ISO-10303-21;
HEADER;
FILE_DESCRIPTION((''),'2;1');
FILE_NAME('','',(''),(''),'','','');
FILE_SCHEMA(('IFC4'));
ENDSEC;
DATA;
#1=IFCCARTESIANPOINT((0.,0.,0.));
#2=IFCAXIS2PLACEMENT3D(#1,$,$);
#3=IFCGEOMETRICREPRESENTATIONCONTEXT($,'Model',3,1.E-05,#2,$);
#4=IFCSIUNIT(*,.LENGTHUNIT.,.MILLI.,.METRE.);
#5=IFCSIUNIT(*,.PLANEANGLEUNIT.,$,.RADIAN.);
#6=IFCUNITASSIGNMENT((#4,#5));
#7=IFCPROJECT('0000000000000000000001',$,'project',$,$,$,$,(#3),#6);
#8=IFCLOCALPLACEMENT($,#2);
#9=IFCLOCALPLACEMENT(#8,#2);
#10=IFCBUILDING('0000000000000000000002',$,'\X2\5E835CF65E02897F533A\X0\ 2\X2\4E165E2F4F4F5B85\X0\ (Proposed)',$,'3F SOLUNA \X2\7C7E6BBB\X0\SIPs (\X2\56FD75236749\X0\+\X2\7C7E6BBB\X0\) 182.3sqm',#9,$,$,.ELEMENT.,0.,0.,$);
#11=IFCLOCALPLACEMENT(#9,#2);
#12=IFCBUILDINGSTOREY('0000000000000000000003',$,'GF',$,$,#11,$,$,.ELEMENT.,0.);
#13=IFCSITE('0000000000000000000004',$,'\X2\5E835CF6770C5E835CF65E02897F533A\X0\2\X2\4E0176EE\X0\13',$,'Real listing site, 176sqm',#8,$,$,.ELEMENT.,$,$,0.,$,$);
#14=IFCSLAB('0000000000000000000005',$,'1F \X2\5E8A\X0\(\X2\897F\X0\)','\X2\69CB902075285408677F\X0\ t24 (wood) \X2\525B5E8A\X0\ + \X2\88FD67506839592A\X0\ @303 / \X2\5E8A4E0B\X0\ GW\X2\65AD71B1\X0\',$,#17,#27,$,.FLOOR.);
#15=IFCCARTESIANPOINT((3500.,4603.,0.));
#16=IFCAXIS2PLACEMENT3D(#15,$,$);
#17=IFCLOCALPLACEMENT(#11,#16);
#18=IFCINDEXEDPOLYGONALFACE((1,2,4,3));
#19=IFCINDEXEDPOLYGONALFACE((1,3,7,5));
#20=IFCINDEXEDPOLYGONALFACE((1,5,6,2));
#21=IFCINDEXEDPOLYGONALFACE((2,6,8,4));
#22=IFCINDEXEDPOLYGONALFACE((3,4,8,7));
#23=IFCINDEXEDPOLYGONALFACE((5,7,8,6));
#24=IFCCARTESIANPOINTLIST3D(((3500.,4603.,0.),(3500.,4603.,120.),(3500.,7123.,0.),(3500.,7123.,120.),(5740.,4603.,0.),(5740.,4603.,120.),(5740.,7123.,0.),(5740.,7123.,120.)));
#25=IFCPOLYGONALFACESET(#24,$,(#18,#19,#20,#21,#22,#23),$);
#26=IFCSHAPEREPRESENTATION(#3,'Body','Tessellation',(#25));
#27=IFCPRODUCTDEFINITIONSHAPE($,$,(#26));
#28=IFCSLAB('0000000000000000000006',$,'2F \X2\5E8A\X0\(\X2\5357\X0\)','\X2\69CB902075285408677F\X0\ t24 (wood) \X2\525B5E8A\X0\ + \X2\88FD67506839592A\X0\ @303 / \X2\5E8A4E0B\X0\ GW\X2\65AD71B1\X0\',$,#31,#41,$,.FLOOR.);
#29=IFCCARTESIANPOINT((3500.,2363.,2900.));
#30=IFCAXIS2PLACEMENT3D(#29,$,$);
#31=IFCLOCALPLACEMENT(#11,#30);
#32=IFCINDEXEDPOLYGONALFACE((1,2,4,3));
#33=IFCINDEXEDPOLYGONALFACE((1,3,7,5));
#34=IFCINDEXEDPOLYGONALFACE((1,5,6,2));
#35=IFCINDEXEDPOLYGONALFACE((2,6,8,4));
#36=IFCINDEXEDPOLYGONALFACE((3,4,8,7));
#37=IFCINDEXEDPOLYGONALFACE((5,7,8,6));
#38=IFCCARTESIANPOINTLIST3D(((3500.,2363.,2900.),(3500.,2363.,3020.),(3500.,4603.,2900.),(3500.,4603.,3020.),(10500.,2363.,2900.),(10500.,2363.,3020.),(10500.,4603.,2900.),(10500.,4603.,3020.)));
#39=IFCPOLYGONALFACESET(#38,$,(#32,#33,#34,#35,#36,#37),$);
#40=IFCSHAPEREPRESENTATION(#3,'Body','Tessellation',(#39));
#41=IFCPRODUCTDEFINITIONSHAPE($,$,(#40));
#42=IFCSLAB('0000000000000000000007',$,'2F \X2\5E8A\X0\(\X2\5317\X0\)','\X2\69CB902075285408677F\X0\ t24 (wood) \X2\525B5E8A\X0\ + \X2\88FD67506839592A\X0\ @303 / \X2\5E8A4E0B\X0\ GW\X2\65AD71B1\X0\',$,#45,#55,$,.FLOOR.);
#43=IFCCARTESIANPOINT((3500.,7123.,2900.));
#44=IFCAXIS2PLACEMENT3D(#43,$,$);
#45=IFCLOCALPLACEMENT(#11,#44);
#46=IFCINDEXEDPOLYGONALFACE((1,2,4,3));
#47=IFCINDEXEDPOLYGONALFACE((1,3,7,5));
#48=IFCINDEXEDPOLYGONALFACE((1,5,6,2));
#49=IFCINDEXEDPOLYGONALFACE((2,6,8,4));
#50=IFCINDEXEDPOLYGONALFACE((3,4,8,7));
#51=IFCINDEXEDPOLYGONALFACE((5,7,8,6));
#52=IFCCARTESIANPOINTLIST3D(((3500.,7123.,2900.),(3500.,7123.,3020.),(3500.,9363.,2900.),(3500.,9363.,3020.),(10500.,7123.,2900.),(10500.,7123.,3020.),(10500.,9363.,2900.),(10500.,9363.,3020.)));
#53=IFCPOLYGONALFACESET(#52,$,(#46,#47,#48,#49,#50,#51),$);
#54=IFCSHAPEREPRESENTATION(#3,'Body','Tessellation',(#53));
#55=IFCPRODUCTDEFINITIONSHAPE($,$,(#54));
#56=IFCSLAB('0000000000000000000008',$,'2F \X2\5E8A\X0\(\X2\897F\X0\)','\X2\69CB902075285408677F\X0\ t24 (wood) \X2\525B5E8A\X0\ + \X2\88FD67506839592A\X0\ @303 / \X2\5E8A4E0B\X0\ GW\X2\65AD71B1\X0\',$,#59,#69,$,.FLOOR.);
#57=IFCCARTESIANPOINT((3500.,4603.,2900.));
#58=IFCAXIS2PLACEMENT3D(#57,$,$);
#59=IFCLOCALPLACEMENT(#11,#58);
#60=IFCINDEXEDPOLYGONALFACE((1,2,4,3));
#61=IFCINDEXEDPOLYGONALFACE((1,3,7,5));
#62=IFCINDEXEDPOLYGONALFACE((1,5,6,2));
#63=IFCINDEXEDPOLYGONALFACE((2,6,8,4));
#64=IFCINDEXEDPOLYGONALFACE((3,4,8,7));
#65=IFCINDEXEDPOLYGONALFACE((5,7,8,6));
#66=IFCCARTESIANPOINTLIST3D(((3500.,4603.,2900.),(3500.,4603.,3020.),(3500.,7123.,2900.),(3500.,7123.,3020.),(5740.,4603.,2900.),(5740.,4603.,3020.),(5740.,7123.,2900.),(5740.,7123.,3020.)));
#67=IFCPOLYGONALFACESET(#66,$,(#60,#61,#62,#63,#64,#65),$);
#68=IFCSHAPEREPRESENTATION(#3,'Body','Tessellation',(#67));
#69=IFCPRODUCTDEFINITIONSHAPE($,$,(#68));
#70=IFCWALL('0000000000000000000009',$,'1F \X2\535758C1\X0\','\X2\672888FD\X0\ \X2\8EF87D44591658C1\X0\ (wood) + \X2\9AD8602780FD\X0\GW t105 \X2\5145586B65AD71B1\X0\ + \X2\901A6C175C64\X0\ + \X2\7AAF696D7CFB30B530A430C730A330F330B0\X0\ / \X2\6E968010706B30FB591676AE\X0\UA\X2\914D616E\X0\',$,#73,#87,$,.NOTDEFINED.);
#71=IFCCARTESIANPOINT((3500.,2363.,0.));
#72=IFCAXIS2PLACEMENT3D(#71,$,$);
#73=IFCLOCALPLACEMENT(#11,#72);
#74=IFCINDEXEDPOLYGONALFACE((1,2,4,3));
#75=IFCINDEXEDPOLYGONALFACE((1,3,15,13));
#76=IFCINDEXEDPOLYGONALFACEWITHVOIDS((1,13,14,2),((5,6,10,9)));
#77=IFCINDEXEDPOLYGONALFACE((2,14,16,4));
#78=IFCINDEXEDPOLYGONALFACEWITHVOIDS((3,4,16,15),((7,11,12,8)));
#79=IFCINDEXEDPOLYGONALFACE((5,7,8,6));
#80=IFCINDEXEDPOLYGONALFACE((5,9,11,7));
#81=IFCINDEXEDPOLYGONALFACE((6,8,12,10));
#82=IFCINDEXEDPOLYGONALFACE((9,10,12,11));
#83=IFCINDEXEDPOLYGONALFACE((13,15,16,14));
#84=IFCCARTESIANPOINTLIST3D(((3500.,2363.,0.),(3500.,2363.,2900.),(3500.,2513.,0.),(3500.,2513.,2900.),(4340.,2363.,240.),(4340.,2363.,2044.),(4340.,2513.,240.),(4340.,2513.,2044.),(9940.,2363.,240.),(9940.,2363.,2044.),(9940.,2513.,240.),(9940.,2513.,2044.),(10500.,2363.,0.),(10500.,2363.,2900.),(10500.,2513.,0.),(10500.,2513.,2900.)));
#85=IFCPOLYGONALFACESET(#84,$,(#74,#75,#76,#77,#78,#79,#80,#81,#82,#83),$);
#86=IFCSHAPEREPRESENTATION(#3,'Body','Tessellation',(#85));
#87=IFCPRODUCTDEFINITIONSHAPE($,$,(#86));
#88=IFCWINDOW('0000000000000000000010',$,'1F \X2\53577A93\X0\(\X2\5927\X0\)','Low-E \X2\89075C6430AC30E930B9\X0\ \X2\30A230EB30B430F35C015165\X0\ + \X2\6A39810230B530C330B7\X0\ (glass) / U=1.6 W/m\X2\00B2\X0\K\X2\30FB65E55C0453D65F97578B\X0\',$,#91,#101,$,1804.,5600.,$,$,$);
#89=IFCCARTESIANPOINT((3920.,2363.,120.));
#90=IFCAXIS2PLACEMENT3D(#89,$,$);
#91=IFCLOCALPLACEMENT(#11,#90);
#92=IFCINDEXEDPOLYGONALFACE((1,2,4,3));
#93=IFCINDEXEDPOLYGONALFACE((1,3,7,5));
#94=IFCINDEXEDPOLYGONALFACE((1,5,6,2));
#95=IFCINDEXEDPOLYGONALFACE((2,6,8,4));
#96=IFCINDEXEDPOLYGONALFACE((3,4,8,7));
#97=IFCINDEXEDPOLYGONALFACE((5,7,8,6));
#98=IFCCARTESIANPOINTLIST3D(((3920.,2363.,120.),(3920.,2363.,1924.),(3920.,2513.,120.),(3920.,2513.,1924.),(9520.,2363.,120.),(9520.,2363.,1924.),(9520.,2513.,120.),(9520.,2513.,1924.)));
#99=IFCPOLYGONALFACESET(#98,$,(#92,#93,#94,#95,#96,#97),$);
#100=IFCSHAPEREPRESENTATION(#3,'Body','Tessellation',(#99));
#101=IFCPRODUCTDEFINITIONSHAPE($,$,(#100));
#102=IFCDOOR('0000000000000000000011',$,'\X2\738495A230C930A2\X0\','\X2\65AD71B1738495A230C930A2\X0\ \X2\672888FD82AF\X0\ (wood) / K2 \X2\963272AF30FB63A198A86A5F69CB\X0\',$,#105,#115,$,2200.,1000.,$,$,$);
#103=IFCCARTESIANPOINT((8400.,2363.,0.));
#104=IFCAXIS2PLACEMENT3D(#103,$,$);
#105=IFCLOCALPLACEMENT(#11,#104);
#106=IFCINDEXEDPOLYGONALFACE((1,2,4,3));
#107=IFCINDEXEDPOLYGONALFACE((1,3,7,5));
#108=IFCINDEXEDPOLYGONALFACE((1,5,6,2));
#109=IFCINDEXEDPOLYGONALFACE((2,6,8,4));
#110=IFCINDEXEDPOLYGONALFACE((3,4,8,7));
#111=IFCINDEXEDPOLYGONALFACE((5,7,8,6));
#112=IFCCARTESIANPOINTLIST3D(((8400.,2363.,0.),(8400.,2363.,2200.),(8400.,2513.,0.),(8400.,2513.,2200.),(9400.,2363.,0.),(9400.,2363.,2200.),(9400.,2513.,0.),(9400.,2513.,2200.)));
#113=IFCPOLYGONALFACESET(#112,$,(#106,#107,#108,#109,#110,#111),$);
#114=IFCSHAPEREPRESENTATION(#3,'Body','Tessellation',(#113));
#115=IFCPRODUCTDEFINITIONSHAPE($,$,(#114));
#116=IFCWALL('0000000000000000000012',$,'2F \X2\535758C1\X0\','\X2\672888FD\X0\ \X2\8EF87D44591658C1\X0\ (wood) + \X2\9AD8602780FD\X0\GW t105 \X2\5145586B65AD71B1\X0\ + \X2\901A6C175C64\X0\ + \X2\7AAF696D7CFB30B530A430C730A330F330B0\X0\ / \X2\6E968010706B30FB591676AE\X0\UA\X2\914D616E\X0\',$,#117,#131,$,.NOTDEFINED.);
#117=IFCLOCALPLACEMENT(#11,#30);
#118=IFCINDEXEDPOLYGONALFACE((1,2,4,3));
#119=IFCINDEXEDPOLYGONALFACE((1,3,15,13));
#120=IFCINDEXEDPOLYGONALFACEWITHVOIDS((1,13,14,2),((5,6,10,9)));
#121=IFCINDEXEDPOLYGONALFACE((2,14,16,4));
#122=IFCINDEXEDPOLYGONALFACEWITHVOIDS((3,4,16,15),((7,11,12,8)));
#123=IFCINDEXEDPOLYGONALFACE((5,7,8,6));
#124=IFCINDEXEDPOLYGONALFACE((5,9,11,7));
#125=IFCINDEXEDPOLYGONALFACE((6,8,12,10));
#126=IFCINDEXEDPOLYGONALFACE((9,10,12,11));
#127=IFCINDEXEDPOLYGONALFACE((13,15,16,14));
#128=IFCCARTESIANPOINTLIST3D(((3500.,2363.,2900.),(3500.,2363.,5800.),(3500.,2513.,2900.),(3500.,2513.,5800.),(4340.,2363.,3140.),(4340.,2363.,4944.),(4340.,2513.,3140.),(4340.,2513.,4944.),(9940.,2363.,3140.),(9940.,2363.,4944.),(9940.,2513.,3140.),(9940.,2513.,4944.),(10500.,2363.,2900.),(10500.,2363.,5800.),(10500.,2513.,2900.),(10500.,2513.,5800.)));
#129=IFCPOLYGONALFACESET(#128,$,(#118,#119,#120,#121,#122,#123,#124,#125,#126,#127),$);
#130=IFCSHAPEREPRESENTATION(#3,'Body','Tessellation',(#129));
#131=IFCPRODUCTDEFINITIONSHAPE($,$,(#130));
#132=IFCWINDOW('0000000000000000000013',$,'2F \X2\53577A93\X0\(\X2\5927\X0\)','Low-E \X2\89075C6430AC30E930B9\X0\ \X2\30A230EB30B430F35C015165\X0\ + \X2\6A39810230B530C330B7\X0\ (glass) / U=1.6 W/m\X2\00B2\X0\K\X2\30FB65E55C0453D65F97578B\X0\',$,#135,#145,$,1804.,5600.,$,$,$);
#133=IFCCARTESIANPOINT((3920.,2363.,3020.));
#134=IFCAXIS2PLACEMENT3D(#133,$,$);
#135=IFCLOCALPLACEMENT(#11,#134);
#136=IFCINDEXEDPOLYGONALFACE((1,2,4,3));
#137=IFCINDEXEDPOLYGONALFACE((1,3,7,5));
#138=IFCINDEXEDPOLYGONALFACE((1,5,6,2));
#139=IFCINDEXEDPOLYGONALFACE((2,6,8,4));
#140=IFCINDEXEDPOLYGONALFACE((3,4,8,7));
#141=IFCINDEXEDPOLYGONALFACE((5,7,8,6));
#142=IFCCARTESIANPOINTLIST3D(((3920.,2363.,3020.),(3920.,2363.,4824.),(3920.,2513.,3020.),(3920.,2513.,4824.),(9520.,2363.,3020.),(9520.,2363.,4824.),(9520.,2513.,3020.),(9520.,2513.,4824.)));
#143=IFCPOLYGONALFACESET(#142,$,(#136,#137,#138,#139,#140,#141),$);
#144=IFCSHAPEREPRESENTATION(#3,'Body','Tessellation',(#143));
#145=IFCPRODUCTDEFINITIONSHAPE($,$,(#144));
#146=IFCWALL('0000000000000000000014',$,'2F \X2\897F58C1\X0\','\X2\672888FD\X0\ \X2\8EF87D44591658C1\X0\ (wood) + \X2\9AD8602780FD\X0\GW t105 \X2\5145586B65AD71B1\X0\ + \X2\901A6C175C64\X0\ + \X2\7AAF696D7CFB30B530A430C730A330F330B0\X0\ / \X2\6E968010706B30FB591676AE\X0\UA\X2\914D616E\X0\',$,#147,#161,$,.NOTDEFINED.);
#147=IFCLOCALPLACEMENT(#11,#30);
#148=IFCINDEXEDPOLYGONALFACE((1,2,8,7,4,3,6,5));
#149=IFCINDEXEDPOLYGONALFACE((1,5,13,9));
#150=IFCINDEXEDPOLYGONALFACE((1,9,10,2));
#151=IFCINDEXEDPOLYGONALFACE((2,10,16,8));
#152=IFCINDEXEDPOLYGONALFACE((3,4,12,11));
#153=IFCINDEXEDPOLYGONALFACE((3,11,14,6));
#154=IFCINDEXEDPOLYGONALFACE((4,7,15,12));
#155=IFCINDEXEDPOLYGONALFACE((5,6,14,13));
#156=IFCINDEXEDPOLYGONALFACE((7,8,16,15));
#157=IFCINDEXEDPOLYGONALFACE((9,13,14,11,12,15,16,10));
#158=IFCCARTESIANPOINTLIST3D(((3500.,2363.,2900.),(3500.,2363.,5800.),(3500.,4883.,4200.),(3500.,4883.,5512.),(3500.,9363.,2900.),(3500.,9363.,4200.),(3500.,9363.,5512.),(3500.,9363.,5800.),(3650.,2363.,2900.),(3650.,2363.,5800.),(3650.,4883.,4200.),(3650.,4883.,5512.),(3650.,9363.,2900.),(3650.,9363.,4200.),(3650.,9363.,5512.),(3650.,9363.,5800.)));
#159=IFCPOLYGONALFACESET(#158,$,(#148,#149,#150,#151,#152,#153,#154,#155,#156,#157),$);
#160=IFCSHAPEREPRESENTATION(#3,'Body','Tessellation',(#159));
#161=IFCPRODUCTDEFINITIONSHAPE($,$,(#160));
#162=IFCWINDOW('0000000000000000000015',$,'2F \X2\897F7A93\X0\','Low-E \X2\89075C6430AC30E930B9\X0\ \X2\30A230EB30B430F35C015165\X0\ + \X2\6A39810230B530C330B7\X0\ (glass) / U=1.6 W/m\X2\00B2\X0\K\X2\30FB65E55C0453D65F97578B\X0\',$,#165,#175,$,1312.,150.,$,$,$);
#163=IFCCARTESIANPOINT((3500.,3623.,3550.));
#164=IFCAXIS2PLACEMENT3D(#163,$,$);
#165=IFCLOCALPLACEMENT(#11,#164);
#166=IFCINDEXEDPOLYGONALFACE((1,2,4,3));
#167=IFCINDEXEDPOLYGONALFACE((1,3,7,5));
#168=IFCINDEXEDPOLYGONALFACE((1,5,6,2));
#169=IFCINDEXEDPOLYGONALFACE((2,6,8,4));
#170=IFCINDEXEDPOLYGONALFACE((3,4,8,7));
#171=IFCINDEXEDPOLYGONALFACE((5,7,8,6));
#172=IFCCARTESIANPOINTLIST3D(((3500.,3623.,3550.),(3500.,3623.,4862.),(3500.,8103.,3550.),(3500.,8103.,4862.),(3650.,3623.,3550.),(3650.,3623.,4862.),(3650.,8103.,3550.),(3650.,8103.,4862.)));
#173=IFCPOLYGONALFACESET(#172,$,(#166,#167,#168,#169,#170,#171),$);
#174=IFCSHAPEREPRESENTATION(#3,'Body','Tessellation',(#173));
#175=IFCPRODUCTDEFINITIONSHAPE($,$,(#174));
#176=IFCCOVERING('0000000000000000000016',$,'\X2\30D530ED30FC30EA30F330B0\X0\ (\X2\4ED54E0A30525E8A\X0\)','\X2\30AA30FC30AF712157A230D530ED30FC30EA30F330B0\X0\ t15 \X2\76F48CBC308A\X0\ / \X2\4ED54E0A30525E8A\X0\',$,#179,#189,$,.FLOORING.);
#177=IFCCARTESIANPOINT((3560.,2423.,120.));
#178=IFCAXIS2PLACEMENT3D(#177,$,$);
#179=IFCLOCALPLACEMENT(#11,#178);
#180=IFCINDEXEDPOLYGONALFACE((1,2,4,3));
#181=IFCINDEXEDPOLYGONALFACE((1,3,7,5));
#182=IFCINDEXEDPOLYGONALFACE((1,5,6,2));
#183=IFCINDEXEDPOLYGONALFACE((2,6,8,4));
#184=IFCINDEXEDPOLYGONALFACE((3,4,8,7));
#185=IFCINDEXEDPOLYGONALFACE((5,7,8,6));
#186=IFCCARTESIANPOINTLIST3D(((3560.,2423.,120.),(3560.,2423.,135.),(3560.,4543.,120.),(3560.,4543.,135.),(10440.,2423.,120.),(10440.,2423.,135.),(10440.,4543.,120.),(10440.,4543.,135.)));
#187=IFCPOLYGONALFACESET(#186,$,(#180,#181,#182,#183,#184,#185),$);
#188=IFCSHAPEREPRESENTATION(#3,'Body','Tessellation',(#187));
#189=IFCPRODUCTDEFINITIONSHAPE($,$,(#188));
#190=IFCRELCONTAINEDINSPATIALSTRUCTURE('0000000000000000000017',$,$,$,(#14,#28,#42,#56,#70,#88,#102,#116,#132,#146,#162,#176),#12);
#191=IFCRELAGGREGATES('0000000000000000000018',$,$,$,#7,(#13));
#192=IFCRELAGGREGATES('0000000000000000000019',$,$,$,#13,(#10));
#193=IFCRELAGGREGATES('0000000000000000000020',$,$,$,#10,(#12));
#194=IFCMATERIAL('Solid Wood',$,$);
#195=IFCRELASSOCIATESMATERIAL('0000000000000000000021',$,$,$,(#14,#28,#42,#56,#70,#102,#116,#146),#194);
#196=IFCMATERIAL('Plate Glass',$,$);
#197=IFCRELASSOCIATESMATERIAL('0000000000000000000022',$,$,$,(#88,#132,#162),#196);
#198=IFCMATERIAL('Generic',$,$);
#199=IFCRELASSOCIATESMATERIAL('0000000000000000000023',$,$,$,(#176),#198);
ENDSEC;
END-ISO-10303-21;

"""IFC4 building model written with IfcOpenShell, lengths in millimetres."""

from ifc_helpers import new_model, si_unit, frame, frame_2d, origin, place, context, project, spatial, rectangle, extrude, material, element, fill, save


model = new_model("IFC4")

# Units and contexts
model_context = context("Model", 3, precision=1e-05, world=origin())
ifc_project = project(units=[si_unit("LENGTHUNIT", "METRE", prefix="MILLI"), si_unit("PLANEANGLEUNIT", "RADIAN")], contexts=[model_context])

# Site, building, storey
site_placement = place(None, origin())
site = spatial("IfcSite", under=ifc_project, at=site_placement, Name="広島県広島市西区2丁目13", ObjectType="Real listing site, 176sqm", CompositionType="ELEMENT", RefElevation=0.0)
building_placement = place(site_placement, origin())
building = spatial("IfcBuilding", under=site, at=building_placement, Name="広島市西区 2世帯住宅 (Proposed)", ObjectType="3F SOLUNA 籾殻SIPs (国産杉+籾殻) 182.3sqm", CompositionType="ELEMENT", ElevationOfRefHeight=0.0, ElevationOfTerrain=0.0)
storey_placement = place(building_placement, origin())
storey = spatial("IfcBuildingStorey", under=building, at=storey_placement, Name="GF", CompositionType="ELEMENT", Elevation=0.0)

# Slabs
ifc_material_1 = material(Name="Solid Wood")
slab_1_placement = place(storey_placement, frame((3500.0, 4603.0, 0.0)))
element("IfcSlab", 1, at=slab_1_placement, inside=storey, material=ifc_material_1, Name="1F 床(西)", Description="構造用合板 t24 (wood) 剛床 + 製材根太 @303 / 床下 GW断熱", PredefinedType="FLOOR", context=model_context, shape_type="SweptSolid", body=[
    extrude(rectangle(XDim=2240.0, YDim=2520.0, at=frame_2d((1120.0, 1260.0))), frame((3500.0, 4603.0, 0.0)), (0.0, 0.0, 1.0), 120.0),
])
slab_2_placement = place(storey_placement, frame((3500.0, 2363.0, 2900.0)))
element("IfcSlab", 2, at=slab_2_placement, inside=storey, material=ifc_material_1, Name="2F 床(南)", Description="構造用合板 t24 (wood) 剛床 + 製材根太 @303 / 床下 GW断熱", PredefinedType="FLOOR", context=model_context, shape_type="SweptSolid", body=[
    extrude(rectangle(XDim=7000.0, YDim=2240.0, at=frame_2d((3500.0, 1120.0))), frame((3500.0, 2363.0, 2900.0)), (0.0, 0.0, 1.0), 120.0),
])
slab_3_placement = place(storey_placement, frame((3500.0, 7123.0, 2900.0)))
element("IfcSlab", 3, at=slab_3_placement, inside=storey, material=ifc_material_1, Name="2F 床(北)", Description="構造用合板 t24 (wood) 剛床 + 製材根太 @303 / 床下 GW断熱", PredefinedType="FLOOR", context=model_context, shape_type="SweptSolid", body=[
    extrude(rectangle(XDim=7000.0, YDim=2240.0, at=frame_2d((3500.0, 1120.0))), frame((3500.0, 7123.0, 2900.0)), (0.0, 0.0, 1.0), 120.0),
])
slab_4_placement = place(storey_placement, frame((3500.0, 4603.0, 2900.0)))
element("IfcSlab", 4, at=slab_4_placement, inside=storey, material=ifc_material_1, Name="2F 床(西)", Description="構造用合板 t24 (wood) 剛床 + 製材根太 @303 / 床下 GW断熱", PredefinedType="FLOOR", context=model_context, shape_type="SweptSolid", body=[
    extrude(rectangle(XDim=2240.0, YDim=2520.0, at=frame_2d((1120.0, 1260.0))), frame((3500.0, 4603.0, 2900.0)), (0.0, 0.0, 1.0), 120.0),
])

# Wall, openings, window, door
wall_1_placement = place(storey_placement, frame((3500.0, 2363.0, 0.0)))
wall_1 = element("IfcWall", 5, at=wall_1_placement, inside=storey, material=ifc_material_1, Name="1F 南壁", Description="木製 軸組外壁 (wood) + 高性能GW t105 充填断熱 + 通気層 + 窯業系サイディング / 準耐火・外皮UA配慮", PredefinedType="NOTDEFINED", context=model_context, shape_type="SweptSolid", body=[
    extrude(rectangle(XDim=7000.0, YDim=150.0, at=frame_2d((3500.0, 75.0))), frame((3500.0, 2363.0, 0.0)), (0.0, 0.0, 1.0), 2900.0),
])
opening_1_placement = place(storey_placement, frame((3920.0, 2363.0, 120.0)))
opening_1 = element("IfcOpeningElement", 6, at=opening_1_placement, cuts=wall_1, PredefinedType="NOTDEFINED", context=model_context, shape_type="SweptSolid", body=[
    extrude(rectangle(XDim=5600.0, YDim=150.0, at=frame_2d((2800.0, 75.0))), frame((3920.0, 2363.0, 120.0)), (0.0, 0.0, 1.0), 1804.0),
])
opening_2_placement = place(storey_placement, frame((8400.0, 2363.0, 0.0)))
opening_2 = element("IfcOpeningElement", 7, at=opening_2_placement, cuts=wall_1, PredefinedType="NOTDEFINED", context=model_context, shape_type="SweptSolid", body=[
    extrude(rectangle(XDim=1000.0, YDim=150.0, at=frame_2d((500.0, 75.0))), frame((8400.0, 2363.0, 0.0)), (0.0, 0.0, 1.0), 2200.0),
])
ifc_material_2 = material(Name="Plate Glass")
window_1_placement = place(storey_placement, frame((3920.0, 2363.0, 120.0)))
window_1 = element("IfcWindow", 8, at=window_1_placement, inside=storey, material=ifc_material_2, Name="1F 南窓(大)", Description="Low-E 複層ガラス アルゴン封入 + 樹脂サッシ (glass) / U=1.6 W/m²K・日射取得型", OverallHeight=1804.0, OverallWidth=5600.0, context=model_context, shape_type="SweptSolid", body=[
    extrude(rectangle(XDim=5600.0, YDim=150.0, at=frame_2d((2800.0, 75.0))), frame((3920.0, 2363.0, 120.0)), (0.0, 0.0, 1.0), 1804.0),
])
fill(opening_1, window_1)
door_placement = place(storey_placement, frame((8400.0, 2363.0, 0.0)))
door = element("IfcDoor", 9, at=door_placement, inside=storey, material=ifc_material_1, Name="玄関ドア", Description="断熱玄関ドア 木製芯 (wood) / K2 防犯・採風機構", OverallHeight=2200.0, OverallWidth=1000.0, context=model_context, shape_type="SweptSolid", body=[
    extrude(rectangle(XDim=1000.0, YDim=150.0, at=frame_2d((500.0, 75.0))), frame((8400.0, 2363.0, 0.0)), (0.0, 0.0, 1.0), 2200.0),
])
fill(opening_2, door)

# Wall, opening, window
wall_2_placement = place(storey_placement, frame((3500.0, 2363.0, 2900.0)))
wall_2 = element("IfcWall", 10, at=wall_2_placement, inside=storey, material=ifc_material_1, Name="2F 南壁", Description="木製 軸組外壁 (wood) + 高性能GW t105 充填断熱 + 通気層 + 窯業系サイディング / 準耐火・外皮UA配慮", PredefinedType="NOTDEFINED", context=model_context, shape_type="SweptSolid", body=[
    extrude(rectangle(XDim=7000.0, YDim=150.0, at=frame_2d((3500.0, 75.0))), frame((3500.0, 2363.0, 2900.0)), (0.0, 0.0, 1.0), 2900.0),
])
opening_3_placement = place(storey_placement, frame((3920.0, 2363.0, 3020.0)))
opening_3 = element("IfcOpeningElement", 11, at=opening_3_placement, cuts=wall_2, PredefinedType="NOTDEFINED", context=model_context, shape_type="SweptSolid", body=[
    extrude(rectangle(XDim=5600.0, YDim=150.0, at=frame_2d((2800.0, 75.0))), frame((3920.0, 2363.0, 3020.0)), (0.0, 0.0, 1.0), 1804.0),
])
window_2_placement = place(storey_placement, frame((3920.0, 2363.0, 3020.0)))
window_2 = element("IfcWindow", 12, at=window_2_placement, inside=storey, material=ifc_material_2, Name="2F 南窓(大)", Description="Low-E 複層ガラス アルゴン封入 + 樹脂サッシ (glass) / U=1.6 W/m²K・日射取得型", OverallHeight=1804.0, OverallWidth=5600.0, context=model_context, shape_type="SweptSolid", body=[
    extrude(rectangle(XDim=5600.0, YDim=150.0, at=frame_2d((2800.0, 75.0))), frame((3920.0, 2363.0, 3020.0)), (0.0, 0.0, 1.0), 1804.0),
])
fill(opening_3, window_2)

# Wall, opening, window
wall_3_placement = place(storey_placement, frame((3500.0, 2363.0, 2900.0)))
wall_3 = element("IfcWall", 13, at=wall_3_placement, inside=storey, material=ifc_material_1, Name="2F 西壁", Description="木製 軸組外壁 (wood) + 高性能GW t105 充填断熱 + 通気層 + 窯業系サイディング / 準耐火・外皮UA配慮", PredefinedType="NOTDEFINED", context=model_context, shape_type="SweptSolid", body=[
    extrude(rectangle(XDim=150.0, YDim=7000.0, at=frame_2d((75.0, 3500.0))), frame((3500.0, 2363.0, 2900.0)), (0.0, 0.0, 1.0), 2900.0),
])
opening_4_placement = place(storey_placement, frame((3500.0, 3623.0, 3550.0)))
opening_4 = element("IfcOpeningElement", 14, at=opening_4_placement, cuts=wall_3, PredefinedType="NOTDEFINED", context=model_context, shape_type="SweptSolid", body=[
    extrude(rectangle(XDim=150.0, YDim=4480.0, at=frame_2d((75.0, 2240.0))), frame((3500.0, 3623.0, 3550.0)), (0.0, 0.0, 1.0), 1312.0),
])
window_3_placement = place(storey_placement, frame((3500.0, 3623.0, 3550.0)))
window_3 = element("IfcWindow", 15, at=window_3_placement, inside=storey, material=ifc_material_2, Name="2F 西窓", Description="Low-E 複層ガラス アルゴン封入 + 樹脂サッシ (glass) / U=1.6 W/m²K・日射取得型", OverallHeight=1312.0, OverallWidth=150.0, context=model_context, shape_type="SweptSolid", body=[
    extrude(rectangle(XDim=150.0, YDim=4480.0, at=frame_2d((75.0, 2240.0))), frame((3500.0, 3623.0, 3550.0)), (0.0, 0.0, 1.0), 1312.0),
])
fill(opening_4, window_3)

# Covering
ifc_material_3 = material(Name="Generic")
covering_1_placement = place(storey_placement, frame((3560.0, 2423.0, 120.0)))
element("IfcCovering", 16, at=covering_1_placement, inside=storey, material=ifc_material_3, Name="フローリング (仕上げ床)", Description="オーク無垢フローリング t15 直貼り / 仕上げ床", PredefinedType="FLOORING", context=model_context, shape_type="SweptSolid", body=[
    extrude(rectangle(XDim=6880.0, YDim=2120.0, at=frame_2d((3440.0, 1060.0))), frame((3560.0, 2423.0, 120.0)), (0.0, 0.0, 1.0), 15.0),
])

save(model, "model.ifc")
